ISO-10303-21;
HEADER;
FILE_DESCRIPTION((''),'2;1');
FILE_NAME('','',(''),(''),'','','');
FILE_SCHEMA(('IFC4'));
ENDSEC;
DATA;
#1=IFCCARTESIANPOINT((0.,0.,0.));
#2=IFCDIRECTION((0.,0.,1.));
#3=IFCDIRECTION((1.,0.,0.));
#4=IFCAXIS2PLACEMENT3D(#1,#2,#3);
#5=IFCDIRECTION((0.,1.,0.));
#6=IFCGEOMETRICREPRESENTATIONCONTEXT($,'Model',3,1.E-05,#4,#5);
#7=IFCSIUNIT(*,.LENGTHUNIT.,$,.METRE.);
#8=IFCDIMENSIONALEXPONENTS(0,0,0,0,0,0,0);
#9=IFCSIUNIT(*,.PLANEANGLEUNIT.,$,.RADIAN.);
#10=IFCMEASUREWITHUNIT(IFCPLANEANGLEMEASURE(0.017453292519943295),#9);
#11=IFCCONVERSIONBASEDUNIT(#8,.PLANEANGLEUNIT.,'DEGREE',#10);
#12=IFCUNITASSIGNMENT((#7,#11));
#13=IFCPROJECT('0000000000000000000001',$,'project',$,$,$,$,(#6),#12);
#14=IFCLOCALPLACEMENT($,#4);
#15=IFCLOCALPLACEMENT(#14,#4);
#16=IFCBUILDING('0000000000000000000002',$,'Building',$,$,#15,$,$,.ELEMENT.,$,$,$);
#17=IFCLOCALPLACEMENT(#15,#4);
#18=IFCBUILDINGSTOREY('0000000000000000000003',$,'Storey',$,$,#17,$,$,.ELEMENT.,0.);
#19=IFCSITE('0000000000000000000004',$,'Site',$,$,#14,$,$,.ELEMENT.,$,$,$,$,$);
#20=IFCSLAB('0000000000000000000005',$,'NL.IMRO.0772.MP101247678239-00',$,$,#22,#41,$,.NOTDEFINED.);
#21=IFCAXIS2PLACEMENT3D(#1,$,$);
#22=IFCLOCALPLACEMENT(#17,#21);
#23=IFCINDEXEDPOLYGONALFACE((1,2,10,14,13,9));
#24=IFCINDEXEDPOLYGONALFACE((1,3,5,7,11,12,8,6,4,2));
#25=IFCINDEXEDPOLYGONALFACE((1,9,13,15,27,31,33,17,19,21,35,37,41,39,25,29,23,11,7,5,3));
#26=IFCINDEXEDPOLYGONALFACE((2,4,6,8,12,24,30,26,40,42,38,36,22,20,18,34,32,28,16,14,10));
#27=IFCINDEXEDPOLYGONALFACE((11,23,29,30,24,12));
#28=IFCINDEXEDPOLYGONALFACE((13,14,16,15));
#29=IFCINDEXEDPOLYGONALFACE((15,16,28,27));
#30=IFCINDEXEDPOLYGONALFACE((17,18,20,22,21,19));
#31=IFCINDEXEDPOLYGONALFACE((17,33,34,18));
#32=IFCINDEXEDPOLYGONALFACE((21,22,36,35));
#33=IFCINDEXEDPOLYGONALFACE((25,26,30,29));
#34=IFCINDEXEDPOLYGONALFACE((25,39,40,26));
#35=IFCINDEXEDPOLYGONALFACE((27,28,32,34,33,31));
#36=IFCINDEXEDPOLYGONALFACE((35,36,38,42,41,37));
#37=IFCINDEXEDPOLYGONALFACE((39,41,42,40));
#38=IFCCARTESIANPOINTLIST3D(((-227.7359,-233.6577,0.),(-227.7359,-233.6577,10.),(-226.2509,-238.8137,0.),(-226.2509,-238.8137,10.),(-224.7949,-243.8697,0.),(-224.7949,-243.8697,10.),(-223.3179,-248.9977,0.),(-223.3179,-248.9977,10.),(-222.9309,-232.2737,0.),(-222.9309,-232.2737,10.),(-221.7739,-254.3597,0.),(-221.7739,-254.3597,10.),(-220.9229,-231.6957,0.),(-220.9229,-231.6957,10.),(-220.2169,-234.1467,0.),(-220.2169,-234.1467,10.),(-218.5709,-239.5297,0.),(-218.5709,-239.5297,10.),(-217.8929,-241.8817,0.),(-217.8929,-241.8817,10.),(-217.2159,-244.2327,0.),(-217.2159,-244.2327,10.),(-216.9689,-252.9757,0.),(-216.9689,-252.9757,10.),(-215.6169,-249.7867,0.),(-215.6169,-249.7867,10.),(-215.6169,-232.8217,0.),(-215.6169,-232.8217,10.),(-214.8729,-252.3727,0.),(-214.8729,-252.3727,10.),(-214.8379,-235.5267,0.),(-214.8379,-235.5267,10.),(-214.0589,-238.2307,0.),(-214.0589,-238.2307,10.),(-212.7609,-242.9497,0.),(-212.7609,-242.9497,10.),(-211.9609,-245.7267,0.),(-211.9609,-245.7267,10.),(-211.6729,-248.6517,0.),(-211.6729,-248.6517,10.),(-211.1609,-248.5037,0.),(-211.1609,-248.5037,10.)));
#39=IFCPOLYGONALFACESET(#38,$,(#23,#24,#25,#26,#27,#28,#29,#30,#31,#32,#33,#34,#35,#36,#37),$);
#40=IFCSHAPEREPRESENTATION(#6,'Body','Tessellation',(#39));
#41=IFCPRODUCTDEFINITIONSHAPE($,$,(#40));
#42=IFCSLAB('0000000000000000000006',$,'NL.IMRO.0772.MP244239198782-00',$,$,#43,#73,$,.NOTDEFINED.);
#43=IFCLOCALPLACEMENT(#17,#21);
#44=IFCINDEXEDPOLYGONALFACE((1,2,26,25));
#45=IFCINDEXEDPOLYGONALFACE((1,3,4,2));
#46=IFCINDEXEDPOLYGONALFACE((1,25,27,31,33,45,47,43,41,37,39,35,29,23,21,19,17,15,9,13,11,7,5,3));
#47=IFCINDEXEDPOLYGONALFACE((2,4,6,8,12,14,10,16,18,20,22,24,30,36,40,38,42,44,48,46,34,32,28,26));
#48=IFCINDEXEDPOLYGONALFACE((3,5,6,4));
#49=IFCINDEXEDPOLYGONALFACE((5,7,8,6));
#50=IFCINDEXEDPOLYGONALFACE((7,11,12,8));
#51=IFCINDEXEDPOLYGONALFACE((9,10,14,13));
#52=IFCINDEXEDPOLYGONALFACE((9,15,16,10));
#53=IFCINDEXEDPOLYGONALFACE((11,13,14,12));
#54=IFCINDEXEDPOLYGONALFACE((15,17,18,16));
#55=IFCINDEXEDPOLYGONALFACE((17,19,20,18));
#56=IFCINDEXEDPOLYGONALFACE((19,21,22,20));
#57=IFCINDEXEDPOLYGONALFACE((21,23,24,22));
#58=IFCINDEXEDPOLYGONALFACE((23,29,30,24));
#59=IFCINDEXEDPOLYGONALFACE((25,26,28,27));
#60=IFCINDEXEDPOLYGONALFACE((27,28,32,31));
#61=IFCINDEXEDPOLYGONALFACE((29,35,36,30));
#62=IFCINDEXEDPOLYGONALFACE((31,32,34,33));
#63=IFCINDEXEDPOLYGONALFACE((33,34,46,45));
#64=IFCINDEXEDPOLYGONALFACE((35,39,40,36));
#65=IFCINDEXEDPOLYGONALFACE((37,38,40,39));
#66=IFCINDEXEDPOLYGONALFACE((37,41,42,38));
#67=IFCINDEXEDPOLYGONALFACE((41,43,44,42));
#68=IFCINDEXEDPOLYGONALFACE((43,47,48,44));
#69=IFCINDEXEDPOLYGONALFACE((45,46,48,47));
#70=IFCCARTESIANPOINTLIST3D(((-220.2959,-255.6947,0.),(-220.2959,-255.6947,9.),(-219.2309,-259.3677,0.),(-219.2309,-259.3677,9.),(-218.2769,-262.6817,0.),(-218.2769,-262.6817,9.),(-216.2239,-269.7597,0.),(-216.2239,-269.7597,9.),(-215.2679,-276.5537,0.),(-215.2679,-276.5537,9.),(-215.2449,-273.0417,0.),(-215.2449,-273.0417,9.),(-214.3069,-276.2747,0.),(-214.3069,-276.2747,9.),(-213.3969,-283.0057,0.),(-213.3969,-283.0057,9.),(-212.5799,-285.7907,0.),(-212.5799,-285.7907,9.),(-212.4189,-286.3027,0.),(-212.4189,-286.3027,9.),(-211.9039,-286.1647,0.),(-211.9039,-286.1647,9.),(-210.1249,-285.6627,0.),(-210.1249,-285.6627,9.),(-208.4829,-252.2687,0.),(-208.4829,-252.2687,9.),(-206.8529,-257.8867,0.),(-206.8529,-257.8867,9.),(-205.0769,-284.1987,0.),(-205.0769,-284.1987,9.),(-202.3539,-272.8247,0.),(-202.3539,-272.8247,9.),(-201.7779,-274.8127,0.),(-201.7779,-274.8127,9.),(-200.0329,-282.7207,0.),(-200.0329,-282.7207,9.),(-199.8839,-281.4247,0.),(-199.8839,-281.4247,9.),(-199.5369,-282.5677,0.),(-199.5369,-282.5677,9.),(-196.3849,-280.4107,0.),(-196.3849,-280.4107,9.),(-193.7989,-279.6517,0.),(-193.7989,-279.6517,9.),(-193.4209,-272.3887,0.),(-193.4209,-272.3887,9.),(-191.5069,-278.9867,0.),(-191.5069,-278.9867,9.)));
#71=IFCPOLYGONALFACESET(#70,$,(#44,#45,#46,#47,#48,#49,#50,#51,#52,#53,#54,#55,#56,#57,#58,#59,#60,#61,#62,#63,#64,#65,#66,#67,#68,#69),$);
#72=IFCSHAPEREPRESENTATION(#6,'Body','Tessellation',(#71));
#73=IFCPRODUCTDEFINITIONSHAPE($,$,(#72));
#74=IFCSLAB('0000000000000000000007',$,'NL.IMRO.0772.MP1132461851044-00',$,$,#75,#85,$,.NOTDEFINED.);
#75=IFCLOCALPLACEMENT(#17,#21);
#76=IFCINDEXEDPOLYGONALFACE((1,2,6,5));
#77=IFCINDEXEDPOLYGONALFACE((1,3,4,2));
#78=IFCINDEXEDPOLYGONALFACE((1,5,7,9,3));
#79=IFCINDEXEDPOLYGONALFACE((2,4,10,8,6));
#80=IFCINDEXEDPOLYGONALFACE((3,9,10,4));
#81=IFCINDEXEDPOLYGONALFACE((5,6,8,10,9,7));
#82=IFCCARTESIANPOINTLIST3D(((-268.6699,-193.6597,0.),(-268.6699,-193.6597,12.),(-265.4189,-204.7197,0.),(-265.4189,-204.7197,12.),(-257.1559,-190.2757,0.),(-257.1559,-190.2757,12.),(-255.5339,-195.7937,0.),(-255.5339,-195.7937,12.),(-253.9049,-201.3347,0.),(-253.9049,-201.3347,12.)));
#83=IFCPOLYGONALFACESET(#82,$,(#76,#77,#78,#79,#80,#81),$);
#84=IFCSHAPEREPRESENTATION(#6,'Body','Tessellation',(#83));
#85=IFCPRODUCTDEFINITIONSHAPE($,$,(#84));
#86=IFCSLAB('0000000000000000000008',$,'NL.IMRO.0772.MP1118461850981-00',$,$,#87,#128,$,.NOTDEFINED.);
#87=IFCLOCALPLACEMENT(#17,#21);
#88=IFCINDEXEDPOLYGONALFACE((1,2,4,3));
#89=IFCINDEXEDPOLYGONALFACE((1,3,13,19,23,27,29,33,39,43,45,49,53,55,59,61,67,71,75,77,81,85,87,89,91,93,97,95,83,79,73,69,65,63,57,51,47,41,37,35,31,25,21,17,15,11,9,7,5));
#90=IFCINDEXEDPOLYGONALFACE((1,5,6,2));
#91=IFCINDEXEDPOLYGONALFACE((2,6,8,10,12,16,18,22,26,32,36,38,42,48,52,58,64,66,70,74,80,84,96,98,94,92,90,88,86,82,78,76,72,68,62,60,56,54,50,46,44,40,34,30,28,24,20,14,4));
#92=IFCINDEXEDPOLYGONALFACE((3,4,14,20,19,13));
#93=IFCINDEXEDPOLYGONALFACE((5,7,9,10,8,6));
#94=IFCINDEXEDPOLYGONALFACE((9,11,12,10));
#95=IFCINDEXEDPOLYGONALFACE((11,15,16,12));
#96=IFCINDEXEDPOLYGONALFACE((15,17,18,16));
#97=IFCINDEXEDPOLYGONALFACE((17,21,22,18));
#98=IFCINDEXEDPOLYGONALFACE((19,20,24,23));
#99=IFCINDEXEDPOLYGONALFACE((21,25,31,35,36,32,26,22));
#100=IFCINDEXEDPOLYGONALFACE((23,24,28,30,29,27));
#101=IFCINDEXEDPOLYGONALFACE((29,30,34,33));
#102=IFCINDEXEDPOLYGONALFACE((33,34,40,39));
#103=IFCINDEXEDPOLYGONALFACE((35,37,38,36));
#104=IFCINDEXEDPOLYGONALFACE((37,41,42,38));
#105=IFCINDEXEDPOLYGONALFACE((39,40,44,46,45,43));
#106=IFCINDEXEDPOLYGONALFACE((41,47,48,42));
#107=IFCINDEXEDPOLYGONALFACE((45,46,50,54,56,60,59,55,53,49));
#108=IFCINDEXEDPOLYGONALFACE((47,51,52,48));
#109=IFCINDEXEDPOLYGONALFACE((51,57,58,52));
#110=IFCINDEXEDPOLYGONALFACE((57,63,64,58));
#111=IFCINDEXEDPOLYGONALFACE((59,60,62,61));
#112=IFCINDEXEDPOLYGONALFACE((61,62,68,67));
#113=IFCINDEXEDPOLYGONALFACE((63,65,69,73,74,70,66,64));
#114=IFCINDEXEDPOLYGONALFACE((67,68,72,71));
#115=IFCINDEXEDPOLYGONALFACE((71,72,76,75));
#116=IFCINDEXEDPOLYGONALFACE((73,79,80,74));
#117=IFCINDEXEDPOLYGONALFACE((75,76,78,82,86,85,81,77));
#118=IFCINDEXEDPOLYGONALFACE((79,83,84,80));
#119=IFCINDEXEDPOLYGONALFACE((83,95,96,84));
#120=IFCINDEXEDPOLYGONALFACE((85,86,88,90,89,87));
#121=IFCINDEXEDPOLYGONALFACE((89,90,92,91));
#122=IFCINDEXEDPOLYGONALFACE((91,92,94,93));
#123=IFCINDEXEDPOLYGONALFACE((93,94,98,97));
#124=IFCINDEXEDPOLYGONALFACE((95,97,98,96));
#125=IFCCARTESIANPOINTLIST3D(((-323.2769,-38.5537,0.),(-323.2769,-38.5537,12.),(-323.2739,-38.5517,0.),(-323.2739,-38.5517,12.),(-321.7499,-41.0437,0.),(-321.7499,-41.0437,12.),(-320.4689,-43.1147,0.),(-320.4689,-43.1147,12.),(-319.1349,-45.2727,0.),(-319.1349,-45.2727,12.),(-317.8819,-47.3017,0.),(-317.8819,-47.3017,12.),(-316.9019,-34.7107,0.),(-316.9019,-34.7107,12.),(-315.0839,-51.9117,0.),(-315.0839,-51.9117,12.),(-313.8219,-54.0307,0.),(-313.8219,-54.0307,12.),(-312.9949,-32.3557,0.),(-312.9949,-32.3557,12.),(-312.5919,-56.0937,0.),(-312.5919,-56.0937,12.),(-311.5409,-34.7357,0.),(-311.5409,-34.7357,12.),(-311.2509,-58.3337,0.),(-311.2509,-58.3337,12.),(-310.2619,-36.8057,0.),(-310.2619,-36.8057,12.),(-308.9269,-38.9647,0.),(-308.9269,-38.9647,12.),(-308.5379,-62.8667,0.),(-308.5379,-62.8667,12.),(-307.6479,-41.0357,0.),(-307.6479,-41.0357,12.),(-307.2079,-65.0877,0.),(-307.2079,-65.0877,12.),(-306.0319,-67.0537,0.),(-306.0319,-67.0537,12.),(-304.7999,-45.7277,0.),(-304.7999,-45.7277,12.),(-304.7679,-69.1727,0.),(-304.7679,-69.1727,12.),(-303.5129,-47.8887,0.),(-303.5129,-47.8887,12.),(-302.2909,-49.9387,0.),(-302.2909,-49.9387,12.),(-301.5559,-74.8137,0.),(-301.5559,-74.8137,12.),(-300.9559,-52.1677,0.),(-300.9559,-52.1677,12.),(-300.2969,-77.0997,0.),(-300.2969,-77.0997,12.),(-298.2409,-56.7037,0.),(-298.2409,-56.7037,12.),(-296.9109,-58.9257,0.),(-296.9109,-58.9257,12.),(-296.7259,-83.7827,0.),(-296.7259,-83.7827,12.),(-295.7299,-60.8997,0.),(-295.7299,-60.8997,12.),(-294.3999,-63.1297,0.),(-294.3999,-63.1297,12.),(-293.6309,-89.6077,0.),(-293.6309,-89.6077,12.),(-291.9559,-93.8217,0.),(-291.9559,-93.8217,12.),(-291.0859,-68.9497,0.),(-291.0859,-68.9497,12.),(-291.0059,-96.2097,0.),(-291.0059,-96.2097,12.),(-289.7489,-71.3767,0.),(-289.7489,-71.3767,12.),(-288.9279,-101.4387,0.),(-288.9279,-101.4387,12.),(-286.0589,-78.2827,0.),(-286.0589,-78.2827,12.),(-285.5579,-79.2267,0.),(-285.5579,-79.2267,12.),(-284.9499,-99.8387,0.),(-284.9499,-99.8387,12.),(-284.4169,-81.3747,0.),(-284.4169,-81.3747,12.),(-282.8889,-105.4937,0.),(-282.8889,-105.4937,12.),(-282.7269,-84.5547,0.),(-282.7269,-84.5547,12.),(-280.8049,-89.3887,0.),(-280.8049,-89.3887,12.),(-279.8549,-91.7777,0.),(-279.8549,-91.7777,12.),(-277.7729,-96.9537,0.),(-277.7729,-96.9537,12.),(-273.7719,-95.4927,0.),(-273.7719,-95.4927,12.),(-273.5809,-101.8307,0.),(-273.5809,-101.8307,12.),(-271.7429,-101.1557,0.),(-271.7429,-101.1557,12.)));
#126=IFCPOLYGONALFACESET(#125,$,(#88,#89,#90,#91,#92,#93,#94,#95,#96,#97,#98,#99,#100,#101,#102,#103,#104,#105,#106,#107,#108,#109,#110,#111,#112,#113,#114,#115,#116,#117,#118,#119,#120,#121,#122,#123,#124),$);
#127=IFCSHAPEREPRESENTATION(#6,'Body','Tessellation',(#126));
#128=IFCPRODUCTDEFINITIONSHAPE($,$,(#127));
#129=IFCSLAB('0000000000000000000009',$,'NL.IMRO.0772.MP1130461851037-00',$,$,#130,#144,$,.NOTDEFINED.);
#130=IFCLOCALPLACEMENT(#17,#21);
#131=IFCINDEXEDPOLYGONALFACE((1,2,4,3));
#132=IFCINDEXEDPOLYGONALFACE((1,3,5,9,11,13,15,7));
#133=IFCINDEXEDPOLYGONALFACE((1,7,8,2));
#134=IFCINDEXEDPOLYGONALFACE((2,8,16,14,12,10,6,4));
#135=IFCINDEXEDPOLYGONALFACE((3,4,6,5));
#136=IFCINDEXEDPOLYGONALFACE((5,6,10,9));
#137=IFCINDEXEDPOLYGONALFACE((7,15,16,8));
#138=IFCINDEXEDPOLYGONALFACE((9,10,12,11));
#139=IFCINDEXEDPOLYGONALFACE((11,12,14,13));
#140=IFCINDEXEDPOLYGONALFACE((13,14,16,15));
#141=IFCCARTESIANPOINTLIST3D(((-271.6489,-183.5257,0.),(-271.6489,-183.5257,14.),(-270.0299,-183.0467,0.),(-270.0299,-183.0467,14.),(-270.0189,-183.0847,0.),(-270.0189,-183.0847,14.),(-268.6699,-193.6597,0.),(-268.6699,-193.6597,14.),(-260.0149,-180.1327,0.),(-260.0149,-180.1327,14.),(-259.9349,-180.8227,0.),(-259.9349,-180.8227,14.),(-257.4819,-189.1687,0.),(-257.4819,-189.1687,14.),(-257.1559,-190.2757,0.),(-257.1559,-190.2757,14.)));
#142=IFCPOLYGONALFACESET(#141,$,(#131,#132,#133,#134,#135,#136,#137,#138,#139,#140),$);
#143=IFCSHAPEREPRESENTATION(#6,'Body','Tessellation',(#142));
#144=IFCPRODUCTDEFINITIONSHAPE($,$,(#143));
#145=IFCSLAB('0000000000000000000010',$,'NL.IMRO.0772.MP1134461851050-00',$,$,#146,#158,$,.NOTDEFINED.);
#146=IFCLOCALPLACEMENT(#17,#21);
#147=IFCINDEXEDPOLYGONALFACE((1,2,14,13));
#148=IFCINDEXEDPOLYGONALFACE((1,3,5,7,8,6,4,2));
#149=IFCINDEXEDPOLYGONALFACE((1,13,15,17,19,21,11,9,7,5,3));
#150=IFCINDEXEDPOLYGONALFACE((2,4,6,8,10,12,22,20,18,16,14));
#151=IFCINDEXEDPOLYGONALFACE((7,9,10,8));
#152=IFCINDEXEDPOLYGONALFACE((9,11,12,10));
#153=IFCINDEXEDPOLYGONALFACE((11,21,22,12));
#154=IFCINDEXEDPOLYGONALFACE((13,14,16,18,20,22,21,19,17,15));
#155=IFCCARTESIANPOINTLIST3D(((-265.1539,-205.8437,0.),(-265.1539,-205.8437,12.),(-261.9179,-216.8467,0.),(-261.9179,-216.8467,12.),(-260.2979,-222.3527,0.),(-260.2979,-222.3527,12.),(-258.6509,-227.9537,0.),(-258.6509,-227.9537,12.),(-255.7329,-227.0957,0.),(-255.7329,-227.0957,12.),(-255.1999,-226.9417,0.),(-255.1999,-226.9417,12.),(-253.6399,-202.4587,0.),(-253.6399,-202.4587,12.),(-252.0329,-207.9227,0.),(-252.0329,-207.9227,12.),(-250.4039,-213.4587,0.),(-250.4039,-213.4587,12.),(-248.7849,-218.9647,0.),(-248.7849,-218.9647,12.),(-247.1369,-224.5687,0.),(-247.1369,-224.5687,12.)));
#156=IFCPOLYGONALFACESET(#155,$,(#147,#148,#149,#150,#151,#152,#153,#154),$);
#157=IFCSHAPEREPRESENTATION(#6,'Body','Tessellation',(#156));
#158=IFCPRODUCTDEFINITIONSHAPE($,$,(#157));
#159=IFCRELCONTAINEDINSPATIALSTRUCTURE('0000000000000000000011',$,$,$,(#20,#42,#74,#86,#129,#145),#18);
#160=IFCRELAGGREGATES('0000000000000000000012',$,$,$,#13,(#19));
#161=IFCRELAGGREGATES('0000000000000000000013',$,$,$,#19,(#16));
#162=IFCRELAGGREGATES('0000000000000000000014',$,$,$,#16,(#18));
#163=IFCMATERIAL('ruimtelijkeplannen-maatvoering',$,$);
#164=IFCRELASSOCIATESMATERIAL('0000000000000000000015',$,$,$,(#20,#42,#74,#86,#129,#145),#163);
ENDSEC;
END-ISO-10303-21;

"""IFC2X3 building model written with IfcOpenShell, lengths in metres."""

from ifc_helpers import new_model, entity, si_unit, converted_unit, direction, origin_with_axes, place, context, project, spatial, polyline, outline, extrude, material, element, save


model = new_model("IFC2X3")

# Units and contexts
model_context = context("Model", 3, precision=1e-05, world=origin_with_axes(), true_north=direction((0.0, 1.0, 0.0)))
ifc_project = project(units=[si_unit("LENGTHUNIT", "METRE"), converted_unit("PLANEANGLEUNIT", "DEGREE", entity("IfcPlaneAngleMeasure", 0.017453292519943295), si_unit("PLANEANGLEUNIT", "RADIAN"), dimensions=[0, 0, 0, 0, 0, 0, 0])], contexts=[model_context])

# Site, building, storey
site_placement = place(None, origin_with_axes())
site = spatial("IfcSite", under=ifc_project, at=site_placement, Name="Site", CompositionType="ELEMENT")
building_placement = place(site_placement, origin_with_axes())
building = spatial("IfcBuilding", under=site, at=building_placement, Name="Building", CompositionType="ELEMENT")
storey_placement = place(building_placement, origin_with_axes())
storey = spatial("IfcBuildingStorey", under=building, at=storey_placement, Name="Storey", CompositionType="ELEMENT", Elevation=0.0)

# Slabs
ifc_material = material(Name="ruimtelijkeplannen-maatvoering")
slab_1_placement = place(storey_placement, origin_with_axes())
element("IfcSlab", 1, at=slab_1_placement, inside=storey, material=ifc_material, Name="NL.IMRO.0772.MP101247678239-00", PredefinedType="NOTDEFINED", context=model_context, shape_type="SweptSolid", body=[
    extrude(outline(polyline([(-214.8729, -252.3727), (-216.9689, -252.9757), (-221.7739, -254.3597), (-223.3179, -248.9977), (-224.7949, -243.8697), (-226.2509, -238.8137), (-227.7359, -233.6577), (-222.9309, -232.2737), (-220.9229, -231.6957), (-220.2169, -234.1467), (-215.6169, -232.8217), (-214.8379, -235.5267), (-214.0589, -238.2307), (-218.5709, -239.5297), (-217.8929, -241.8817), (-217.2159, -244.2327), (-212.7609, -242.9497), (-211.9609, -245.7267), (-211.1609, -248.5037), (-211.6729, -248.6517), (-215.6169, -249.7867), (-214.8729, -252.3727)])), origin_with_axes(), (0.0, 0.0, 1.0), 10.0),
])
slab_2_placement = place(storey_placement, origin_with_axes())
element("IfcSlab", 2, at=slab_2_placement, inside=storey, material=ifc_material, Name="NL.IMRO.0772.MP244239198782-00", PredefinedType="NOTDEFINED", context=model_context, shape_type="SweptSolid", body=[
    extrude(outline(polyline([(-196.3849, -280.4107), (-199.8839, -281.4247), (-199.5369, -282.5677), (-200.0329, -282.7207), (-205.0769, -284.1987), (-210.1249, -285.6627), (-211.9039, -286.1647), (-212.4189, -286.3027), (-212.5799, -285.7907), (-213.3969, -283.0057), (-215.2679, -276.5537), (-214.3069, -276.2747), (-215.2449, -273.0417), (-216.2239, -269.7597), (-218.2769, -262.6817), (-219.2309, -259.3677), (-220.2959, -255.6947), (-208.4829, -252.2687), (-206.8529, -257.8867), (-202.3539, -272.8247), (-201.7779, -274.8127), (-193.4209, -272.3887), (-191.5069, -278.9867), (-193.7989, -279.6517), (-196.3849, -280.4107)])), origin_with_axes(), (0.0, 0.0, 1.0), 9.0),
])
slab_3_placement = place(storey_placement, origin_with_axes())
element("IfcSlab", 3, at=slab_3_placement, inside=storey, material=ifc_material, Name="NL.IMRO.0772.MP1132461851044-00", PredefinedType="NOTDEFINED", context=model_context, shape_type="SweptSolid", body=[
    extrude(outline(polyline([(-255.5339, -195.7937), (-253.9049, -201.3347), (-265.4189, -204.7197), (-268.6699, -193.6597), (-257.1559, -190.2757), (-255.5339, -195.7937)])), origin_with_axes(), (0.0, 0.0, 1.0), 12.0),
])
slab_4_placement = place(storey_placement, origin_with_axes())
element("IfcSlab", 4, at=slab_4_placement, inside=storey, material=ifc_material, Name="NL.IMRO.0772.MP1118461850981-00", PredefinedType="NOTDEFINED", context=model_context, shape_type="SweptSolid", body=[
    extrude(outline(polyline([(-273.5809, -101.8307), (-282.8889, -105.4937), (-284.9499, -99.8387), (-288.9279, -101.4387), (-291.0059, -96.2097), (-291.9559, -93.8217), (-293.6309, -89.6077), (-296.7259, -83.7827), (-300.2969, -77.0997), (-301.5559, -74.8137), (-304.7679, -69.1727), (-306.0319, -67.0537), (-307.2079, -65.0877), (-308.5379, -62.8667), (-311.2509, -58.3337), (-312.5919, -56.0937), (-313.8219, -54.0307), (-315.0839, -51.9117), (-317.8819, -47.3017), (-319.1349, -45.2727), (-320.4689, -43.1147), (-321.7499, -41.0437), (-323.2769, -38.5537), (-323.2739, -38.5517), (-316.9019, -34.7107), (-312.9949, -32.3557), (-311.5409, -34.7357), (-310.2619, -36.8057), (-308.9269, -38.9647), (-307.6479, -41.0357), (-304.7999, -45.7277), (-303.5129, -47.8887), (-302.2909, -49.9387), (-300.9559, -52.1677), (-298.2409, -56.7037), (-296.9109, -58.9257), (-295.7299, -60.8997), (-294.3999, -63.1297), (-291.0859, -68.9497), (-289.7489, -71.3767), (-286.0589, -78.2827), (-285.5579, -79.2267), (-284.4169, -81.3747), (-282.7269, -84.5547), (-280.8049, -89.3887), (-279.8549, -91.7777), (-277.7729, -96.9537), (-273.7719, -95.4927), (-271.7429, -101.1557), (-273.5809, -101.8307)])), origin_with_axes(), (0.0, 0.0, 1.0), 12.0),
])
slab_5_placement = place(storey_placement, origin_with_axes())
element("IfcSlab", 5, at=slab_5_placement, inside=storey, material=ifc_material, Name="NL.IMRO.0772.MP1130461851037-00", PredefinedType="NOTDEFINED", context=model_context, shape_type="SweptSolid", body=[
    extrude(outline(polyline([(-268.6699, -193.6597), (-271.6489, -183.5257), (-270.0299, -183.0467), (-270.0189, -183.0847), (-260.0149, -180.1327), (-259.9349, -180.8227), (-257.4819, -189.1687), (-257.1559, -190.2757), (-268.6699, -193.6597)])), origin_with_axes(), (0.0, 0.0, 1.0), 14.0),
])
slab_6_placement = place(storey_placement, origin_with_axes())
element("IfcSlab", 6, at=slab_6_placement, inside=storey, material=ifc_material, Name="NL.IMRO.0772.MP1134461851050-00", PredefinedType="NOTDEFINED", context=model_context, shape_type="SweptSolid", body=[
    extrude(outline(polyline([(-255.7329, -227.0957), (-258.6509, -227.9537), (-260.2979, -222.3527), (-261.9179, -216.8467), (-265.1539, -205.8437), (-253.6399, -202.4587), (-252.0329, -207.9227), (-250.4039, -213.4587), (-248.7849, -218.9647), (-247.1369, -224.5687), (-255.1999, -226.9417), (-255.7329, -227.0957)])), origin_with_axes(), (0.0, 0.0, 1.0), 12.0),
])

save(model, "model.ifc")
